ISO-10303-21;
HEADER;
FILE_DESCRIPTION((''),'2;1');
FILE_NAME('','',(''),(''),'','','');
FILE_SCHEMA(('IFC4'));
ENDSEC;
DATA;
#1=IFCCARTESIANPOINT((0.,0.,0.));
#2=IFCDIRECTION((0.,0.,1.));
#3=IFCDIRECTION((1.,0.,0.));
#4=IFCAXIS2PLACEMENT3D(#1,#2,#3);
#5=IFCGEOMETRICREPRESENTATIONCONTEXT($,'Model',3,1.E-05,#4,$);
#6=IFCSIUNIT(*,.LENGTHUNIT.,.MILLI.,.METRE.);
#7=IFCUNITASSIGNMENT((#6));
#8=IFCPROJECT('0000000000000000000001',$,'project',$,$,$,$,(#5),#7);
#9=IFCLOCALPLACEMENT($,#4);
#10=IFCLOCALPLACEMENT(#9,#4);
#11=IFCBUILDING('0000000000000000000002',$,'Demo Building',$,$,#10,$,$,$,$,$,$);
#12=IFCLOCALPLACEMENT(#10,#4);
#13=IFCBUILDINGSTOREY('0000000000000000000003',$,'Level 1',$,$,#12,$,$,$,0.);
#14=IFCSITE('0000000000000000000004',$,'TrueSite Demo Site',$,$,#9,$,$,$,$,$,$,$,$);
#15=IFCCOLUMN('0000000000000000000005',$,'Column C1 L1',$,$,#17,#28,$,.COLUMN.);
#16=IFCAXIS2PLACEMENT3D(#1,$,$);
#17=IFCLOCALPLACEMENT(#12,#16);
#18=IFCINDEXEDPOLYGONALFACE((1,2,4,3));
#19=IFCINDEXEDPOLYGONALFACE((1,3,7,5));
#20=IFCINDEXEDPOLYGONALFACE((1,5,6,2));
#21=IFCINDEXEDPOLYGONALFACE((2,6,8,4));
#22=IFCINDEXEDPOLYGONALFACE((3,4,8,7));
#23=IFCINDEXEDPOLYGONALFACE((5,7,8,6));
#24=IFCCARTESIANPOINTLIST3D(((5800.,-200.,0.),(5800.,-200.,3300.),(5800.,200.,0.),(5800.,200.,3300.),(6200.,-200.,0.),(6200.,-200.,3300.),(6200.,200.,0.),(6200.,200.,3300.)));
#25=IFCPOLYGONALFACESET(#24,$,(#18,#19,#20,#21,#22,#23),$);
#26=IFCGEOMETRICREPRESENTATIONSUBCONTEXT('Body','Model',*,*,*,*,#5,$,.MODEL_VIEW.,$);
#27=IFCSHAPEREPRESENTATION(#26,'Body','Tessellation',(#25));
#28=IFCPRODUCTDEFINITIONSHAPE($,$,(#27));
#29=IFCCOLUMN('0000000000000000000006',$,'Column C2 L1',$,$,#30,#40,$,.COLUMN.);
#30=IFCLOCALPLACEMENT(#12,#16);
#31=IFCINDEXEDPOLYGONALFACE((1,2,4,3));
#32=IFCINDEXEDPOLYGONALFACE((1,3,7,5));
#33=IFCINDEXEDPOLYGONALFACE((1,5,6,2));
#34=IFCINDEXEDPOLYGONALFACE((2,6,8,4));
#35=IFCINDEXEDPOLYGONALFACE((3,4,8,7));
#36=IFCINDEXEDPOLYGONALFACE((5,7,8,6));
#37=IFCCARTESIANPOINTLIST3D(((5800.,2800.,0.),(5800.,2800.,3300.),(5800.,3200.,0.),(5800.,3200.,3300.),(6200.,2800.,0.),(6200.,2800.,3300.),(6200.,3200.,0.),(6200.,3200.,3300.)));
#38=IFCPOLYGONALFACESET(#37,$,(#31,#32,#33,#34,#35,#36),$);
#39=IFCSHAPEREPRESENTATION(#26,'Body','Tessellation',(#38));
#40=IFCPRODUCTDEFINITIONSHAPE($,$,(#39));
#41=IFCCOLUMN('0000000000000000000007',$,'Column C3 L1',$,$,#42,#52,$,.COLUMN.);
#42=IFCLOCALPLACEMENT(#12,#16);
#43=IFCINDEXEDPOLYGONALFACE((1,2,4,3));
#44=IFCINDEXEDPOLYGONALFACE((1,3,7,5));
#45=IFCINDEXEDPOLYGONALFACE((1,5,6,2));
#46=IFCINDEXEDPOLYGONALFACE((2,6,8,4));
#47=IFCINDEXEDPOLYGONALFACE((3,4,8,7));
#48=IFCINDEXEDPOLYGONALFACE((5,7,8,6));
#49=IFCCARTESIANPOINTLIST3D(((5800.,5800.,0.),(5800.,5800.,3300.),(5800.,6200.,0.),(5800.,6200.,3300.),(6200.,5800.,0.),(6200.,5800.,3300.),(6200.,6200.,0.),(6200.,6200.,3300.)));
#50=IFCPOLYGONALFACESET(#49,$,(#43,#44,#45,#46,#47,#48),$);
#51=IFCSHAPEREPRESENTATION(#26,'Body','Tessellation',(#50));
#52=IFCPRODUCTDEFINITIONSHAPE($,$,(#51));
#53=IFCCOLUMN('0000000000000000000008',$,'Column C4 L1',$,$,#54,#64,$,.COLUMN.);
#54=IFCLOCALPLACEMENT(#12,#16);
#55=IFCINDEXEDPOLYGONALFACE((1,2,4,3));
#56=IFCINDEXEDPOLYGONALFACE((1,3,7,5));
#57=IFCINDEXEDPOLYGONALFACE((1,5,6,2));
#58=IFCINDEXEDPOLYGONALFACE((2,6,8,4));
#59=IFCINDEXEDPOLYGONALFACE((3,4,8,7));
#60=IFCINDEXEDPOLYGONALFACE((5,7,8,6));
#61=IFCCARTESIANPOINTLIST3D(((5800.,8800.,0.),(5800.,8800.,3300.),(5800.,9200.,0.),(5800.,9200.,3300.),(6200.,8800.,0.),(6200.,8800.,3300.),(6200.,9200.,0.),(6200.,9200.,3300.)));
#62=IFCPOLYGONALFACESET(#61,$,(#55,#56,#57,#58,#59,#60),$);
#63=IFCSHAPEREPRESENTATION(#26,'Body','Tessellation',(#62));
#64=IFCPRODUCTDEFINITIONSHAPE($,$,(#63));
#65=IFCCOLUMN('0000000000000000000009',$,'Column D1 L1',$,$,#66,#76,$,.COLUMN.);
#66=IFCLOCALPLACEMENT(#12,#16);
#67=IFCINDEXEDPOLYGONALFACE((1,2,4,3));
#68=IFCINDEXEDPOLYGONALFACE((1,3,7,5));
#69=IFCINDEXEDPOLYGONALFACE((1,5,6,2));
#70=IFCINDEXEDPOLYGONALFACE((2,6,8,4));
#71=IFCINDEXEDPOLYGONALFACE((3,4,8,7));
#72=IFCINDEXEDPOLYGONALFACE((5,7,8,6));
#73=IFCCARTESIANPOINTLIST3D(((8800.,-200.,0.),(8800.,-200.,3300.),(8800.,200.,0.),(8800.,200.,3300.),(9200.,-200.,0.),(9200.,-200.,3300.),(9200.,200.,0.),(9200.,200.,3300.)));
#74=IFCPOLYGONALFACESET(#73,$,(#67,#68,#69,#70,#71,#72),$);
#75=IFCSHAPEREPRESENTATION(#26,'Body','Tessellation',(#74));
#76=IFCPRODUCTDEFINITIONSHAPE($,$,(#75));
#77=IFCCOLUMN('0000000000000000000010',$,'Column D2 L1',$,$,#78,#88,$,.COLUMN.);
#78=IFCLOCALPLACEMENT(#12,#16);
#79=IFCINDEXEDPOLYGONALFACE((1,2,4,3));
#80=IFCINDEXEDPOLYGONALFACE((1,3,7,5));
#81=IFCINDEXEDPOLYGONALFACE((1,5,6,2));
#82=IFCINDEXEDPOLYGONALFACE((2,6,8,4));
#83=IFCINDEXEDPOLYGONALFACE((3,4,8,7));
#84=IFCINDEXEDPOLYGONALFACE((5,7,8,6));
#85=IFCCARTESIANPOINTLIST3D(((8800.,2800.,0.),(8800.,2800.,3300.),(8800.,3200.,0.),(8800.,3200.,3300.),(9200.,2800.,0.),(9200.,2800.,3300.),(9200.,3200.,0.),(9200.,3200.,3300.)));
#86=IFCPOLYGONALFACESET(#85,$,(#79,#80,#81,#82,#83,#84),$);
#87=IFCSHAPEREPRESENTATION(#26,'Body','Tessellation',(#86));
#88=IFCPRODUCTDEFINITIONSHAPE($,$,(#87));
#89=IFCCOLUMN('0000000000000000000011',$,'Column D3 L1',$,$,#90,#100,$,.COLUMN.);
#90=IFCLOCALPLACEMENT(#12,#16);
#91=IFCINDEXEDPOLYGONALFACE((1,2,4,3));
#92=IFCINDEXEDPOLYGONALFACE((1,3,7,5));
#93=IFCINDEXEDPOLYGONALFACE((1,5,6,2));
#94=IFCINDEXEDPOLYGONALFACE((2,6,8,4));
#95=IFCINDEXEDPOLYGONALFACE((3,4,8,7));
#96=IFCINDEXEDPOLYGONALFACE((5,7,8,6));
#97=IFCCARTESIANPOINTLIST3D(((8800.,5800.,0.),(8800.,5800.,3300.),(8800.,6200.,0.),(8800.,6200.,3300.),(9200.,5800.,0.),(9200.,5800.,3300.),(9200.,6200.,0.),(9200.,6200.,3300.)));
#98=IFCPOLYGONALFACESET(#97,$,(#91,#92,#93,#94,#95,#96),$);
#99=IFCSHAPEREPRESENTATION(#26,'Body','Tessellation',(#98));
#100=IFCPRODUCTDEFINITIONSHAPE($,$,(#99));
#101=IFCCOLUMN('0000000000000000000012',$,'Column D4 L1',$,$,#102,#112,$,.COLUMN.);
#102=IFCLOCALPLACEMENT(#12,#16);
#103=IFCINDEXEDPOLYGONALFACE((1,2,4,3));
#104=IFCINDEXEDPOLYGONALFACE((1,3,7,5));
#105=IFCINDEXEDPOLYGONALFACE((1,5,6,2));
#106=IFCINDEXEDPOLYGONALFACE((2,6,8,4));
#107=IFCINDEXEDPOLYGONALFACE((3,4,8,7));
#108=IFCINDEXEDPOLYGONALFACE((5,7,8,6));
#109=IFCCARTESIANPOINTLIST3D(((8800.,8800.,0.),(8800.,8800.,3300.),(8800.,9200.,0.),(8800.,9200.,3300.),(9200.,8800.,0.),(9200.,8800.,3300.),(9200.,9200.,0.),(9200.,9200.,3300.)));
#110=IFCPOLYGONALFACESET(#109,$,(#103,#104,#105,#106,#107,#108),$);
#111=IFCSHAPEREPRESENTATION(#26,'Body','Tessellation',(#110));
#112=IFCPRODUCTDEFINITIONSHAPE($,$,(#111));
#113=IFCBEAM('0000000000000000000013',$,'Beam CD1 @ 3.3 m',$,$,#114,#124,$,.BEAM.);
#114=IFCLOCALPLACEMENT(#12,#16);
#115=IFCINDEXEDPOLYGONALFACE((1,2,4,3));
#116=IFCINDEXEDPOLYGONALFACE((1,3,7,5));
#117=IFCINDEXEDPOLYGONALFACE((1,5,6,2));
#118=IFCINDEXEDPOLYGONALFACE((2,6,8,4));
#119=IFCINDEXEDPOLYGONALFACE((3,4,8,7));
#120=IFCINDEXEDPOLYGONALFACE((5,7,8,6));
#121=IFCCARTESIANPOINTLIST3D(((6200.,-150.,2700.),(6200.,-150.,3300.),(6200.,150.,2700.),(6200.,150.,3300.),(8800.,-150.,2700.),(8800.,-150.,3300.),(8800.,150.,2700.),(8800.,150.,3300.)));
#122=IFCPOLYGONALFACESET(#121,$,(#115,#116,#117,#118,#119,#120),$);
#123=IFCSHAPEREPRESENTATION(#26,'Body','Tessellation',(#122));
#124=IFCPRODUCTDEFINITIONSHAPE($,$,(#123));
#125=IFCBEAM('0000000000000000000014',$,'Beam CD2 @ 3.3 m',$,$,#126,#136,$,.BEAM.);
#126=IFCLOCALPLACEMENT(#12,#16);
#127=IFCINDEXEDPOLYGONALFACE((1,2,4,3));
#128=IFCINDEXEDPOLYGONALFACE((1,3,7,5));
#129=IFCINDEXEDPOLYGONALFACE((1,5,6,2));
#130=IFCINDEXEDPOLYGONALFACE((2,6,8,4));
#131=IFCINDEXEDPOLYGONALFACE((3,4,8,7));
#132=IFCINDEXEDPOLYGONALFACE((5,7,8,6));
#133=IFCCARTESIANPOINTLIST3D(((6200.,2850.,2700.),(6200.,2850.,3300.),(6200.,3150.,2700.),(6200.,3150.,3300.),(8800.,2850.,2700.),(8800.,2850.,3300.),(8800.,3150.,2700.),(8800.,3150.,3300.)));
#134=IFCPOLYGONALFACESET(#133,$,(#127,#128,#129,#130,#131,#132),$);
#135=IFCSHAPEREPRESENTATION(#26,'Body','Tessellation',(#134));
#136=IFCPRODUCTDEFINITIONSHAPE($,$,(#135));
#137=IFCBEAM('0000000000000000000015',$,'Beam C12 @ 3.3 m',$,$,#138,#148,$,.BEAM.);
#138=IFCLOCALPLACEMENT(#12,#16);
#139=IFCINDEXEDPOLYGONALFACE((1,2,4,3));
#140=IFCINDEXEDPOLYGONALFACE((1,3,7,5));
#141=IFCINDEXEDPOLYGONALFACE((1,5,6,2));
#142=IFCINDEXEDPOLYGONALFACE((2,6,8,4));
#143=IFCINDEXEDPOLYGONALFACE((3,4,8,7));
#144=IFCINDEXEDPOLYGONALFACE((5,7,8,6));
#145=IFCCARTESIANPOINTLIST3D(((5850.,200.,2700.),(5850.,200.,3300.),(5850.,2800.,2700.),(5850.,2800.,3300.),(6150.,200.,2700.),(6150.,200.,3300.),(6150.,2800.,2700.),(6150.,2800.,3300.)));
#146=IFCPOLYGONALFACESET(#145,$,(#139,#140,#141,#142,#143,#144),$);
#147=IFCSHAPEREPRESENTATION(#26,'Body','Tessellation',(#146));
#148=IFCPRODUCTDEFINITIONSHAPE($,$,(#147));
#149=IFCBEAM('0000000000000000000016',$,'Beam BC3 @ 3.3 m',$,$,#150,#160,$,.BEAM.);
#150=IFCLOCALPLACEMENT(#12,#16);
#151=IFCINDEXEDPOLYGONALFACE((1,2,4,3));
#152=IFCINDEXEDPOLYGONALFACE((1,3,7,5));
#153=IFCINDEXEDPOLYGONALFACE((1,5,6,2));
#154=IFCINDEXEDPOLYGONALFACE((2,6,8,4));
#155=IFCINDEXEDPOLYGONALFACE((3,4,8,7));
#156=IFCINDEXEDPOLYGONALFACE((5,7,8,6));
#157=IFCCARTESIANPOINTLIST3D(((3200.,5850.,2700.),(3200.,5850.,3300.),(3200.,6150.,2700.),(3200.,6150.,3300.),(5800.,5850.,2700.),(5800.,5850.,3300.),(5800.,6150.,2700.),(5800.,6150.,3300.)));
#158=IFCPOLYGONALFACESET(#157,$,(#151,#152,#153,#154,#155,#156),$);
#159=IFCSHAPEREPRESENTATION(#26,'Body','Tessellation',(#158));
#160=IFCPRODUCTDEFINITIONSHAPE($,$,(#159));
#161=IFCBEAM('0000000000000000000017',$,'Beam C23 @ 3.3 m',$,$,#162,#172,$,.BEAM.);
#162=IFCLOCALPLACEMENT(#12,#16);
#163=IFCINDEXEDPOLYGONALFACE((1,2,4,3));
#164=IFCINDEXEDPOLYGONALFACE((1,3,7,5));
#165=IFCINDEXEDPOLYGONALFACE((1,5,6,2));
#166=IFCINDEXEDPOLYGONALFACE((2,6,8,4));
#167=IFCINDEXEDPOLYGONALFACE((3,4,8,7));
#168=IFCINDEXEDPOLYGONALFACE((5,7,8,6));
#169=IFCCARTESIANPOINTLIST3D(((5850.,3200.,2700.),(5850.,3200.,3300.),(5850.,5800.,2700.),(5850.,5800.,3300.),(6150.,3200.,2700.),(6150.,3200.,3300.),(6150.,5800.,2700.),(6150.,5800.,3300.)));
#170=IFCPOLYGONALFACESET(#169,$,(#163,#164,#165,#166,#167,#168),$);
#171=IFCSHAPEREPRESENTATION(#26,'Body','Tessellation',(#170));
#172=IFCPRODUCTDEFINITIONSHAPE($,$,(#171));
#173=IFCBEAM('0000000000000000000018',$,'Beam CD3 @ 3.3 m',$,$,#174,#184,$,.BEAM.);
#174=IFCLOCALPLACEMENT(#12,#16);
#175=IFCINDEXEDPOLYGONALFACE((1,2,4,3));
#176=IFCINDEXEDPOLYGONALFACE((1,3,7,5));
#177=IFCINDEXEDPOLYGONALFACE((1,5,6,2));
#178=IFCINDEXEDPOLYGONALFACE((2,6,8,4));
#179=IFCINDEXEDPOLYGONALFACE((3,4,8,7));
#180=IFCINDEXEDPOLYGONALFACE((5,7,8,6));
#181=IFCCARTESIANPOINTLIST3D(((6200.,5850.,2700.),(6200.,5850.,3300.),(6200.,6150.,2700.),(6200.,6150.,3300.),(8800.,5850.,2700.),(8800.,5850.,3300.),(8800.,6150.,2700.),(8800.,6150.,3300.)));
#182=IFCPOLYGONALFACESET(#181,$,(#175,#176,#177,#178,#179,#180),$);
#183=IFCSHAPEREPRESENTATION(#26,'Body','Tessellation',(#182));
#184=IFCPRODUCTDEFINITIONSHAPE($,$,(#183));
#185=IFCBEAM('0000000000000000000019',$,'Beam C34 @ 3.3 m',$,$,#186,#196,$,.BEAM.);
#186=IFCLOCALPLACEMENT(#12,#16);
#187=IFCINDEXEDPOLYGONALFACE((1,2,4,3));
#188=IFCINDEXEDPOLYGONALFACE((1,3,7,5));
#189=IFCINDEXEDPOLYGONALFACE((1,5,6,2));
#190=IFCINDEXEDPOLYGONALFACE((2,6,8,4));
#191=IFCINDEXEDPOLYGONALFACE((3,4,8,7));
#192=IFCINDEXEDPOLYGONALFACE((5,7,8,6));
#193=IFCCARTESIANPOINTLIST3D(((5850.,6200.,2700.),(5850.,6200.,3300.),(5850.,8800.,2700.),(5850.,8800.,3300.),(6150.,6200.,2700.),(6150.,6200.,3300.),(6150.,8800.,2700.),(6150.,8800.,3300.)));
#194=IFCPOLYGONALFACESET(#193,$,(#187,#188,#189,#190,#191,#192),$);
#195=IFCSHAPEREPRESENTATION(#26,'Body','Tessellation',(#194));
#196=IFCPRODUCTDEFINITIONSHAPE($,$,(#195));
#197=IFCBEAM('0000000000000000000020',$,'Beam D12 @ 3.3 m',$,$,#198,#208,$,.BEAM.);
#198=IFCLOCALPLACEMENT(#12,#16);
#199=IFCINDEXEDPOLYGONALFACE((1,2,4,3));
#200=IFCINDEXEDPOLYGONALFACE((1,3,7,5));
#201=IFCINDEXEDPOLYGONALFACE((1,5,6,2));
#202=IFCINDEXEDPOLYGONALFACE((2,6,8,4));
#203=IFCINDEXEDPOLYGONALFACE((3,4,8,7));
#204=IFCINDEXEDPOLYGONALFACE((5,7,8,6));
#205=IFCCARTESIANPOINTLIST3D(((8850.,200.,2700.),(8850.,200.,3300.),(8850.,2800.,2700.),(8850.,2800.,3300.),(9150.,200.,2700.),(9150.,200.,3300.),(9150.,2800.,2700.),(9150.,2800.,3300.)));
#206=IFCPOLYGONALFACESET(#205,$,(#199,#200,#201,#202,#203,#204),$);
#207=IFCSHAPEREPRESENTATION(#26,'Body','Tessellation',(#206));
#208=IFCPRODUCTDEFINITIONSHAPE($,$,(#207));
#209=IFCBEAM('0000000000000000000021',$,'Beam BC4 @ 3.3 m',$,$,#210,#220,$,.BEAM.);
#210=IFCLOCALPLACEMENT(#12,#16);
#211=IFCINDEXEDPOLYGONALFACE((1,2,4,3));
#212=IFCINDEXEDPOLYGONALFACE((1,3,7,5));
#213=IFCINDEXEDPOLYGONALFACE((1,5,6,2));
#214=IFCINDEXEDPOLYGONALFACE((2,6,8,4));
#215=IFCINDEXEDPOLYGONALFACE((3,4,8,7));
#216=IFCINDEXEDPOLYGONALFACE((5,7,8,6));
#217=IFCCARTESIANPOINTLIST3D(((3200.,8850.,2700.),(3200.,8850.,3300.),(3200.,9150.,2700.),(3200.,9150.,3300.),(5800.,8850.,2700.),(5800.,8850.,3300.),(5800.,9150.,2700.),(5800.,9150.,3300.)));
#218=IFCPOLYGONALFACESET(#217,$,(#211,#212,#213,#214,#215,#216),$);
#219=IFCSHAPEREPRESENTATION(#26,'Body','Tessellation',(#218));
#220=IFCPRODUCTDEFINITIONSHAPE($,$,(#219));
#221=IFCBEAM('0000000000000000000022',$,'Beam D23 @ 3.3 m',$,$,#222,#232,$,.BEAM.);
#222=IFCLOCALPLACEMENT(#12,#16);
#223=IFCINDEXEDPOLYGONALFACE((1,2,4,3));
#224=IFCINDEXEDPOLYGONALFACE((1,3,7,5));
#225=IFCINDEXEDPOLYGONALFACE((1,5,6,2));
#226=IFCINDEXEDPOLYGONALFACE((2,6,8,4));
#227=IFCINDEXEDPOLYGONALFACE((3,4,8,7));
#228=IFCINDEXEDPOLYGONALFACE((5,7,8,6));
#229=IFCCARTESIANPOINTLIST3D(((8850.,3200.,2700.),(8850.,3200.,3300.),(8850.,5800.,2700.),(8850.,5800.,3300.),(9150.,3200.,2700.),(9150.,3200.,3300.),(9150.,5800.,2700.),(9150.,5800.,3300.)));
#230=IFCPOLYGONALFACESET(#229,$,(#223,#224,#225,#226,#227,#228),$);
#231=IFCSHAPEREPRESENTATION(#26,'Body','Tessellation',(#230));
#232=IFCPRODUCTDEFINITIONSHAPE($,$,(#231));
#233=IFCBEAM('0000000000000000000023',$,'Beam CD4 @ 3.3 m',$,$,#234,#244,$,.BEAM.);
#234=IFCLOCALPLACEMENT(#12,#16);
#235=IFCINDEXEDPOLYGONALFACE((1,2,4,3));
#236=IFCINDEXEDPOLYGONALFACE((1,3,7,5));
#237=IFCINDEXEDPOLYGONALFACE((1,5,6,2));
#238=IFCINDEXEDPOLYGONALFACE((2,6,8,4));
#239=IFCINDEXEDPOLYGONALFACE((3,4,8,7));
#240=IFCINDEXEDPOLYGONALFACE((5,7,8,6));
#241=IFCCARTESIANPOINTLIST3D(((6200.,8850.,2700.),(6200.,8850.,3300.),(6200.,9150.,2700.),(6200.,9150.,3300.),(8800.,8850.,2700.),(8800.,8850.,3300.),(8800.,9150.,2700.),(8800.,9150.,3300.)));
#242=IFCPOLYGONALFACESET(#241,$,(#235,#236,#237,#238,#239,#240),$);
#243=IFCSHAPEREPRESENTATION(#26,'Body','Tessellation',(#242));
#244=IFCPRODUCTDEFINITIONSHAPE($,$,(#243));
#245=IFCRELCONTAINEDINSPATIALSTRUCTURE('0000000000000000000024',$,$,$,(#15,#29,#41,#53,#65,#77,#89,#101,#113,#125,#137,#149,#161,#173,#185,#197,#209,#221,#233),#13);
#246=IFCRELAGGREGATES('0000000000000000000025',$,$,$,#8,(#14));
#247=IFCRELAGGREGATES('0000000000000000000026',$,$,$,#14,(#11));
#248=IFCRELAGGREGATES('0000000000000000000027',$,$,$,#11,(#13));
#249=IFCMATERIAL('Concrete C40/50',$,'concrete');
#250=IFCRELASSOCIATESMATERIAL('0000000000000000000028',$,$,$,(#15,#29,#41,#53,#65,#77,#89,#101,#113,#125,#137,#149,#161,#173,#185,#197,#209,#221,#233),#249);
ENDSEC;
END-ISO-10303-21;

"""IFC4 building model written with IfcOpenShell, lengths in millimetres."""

from ifc_helpers import new_model, si_unit, frame, origin_with_axes, place, context, subcontext, project, spatial, rectangle, extrude, material, element, save


model = new_model("IFC4")

# Units and contexts
model_context = context("Model", 3, precision=1e-05, world=origin_with_axes())
body_context = subcontext(model_context, "Body", "Model", "MODEL_VIEW")
ifc_project = project(units=[si_unit("LENGTHUNIT", "METRE", prefix="MILLI")], contexts=[model_context])

# Site, building, storey
site_placement = place(None, origin_with_axes())
site = spatial("IfcSite", under=ifc_project, at=site_placement, Name="TrueSite Demo Site")
building_placement = place(site_placement, origin_with_axes())
building = spatial("IfcBuilding", under=site, at=building_placement, Name="Demo Building")
storey_placement = place(building_placement, origin_with_axes())
storey = spatial("IfcBuildingStorey", under=building, at=storey_placement, Name="Level 1", Elevation=0.0)

# Columns
ifc_material_1 = material(Name="Concrete C40/50", Category="concrete")
for number, where, z_axis, x_axis, name in (
    (1, (6000.0, 0.0, 0.0), (0.0, 0.0, 1.0), (1.0, 0.0, 0.0), "Column C1 L1"),
    (2, (6000.0, 3000.0, 0.0), (0.0, 0.0, 1.0), (1.0, 0.0, 0.0), "Column C2 L1"),
    (3, (6000.0, 6000.0, 0.0), (0.0, 0.0, 1.0), (1.0, 0.0, 0.0), "Column C3 L1"),
    (4, (6000.0, 9000.0, 0.0), (0.0, 0.0, 1.0), (1.0, 0.0, 0.0), "Column C4 L1"),
    (5, (9000.0, 0.0, 0.0), (0.0, 0.0, 1.0), (1.0, 0.0, 0.0), "Column D1 L1"),
    (6, (9000.0, 3000.0, 0.0), (0.0, 0.0, 1.0), (1.0, 0.0, 0.0), "Column D2 L1"),
    (7, (9000.0, 6000.0, 0.0), (0.0, 0.0, 1.0), (1.0, 0.0, 0.0), "Column D3 L1"),
    (8, (9000.0, 9000.0, 0.0), (0.0, 0.0, 1.0), (1.0, 0.0, 0.0), "Column D4 L1"),
):
    element("IfcColumn", number, at=place(storey_placement, frame(where, z_axis=z_axis, x_axis=x_axis)), inside=storey, material=ifc_material_1, Name=name, PredefinedType="COLUMN", context=body_context, shape_type="SweptSolid", body=[
        extrude(rectangle(XDim=400.0, YDim=400.0), origin_with_axes(), (0.0, 0.0, 1.0), 3300.0),
    ])

# Beams
for number, where, z_axis, x_axis, name in (
    (9, (6200.0, 0.0, 3000.0), (1.0, 0.0, 0.0), (0.0, 1.0, 0.0), "Beam CD1 @ 3.3 m"),
    (10, (6200.0, 3000.0, 3000.0), (1.0, 0.0, 0.0), (0.0, 1.0, 0.0), "Beam CD2 @ 3.3 m"),
):
    element("IfcBeam", number, at=place(storey_placement, frame(where, z_axis=z_axis, x_axis=x_axis)), inside=storey, material=ifc_material_1, Name=name, PredefinedType="BEAM", context=body_context, shape_type="SweptSolid", body=[
        extrude(rectangle(XDim=300.0, YDim=600.0), origin_with_axes(), (0.0, 0.0, 1.0), 2600.0),
    ])
for number, where, z_axis, x_axis, name in (
    (11, (6000.0, 200.0, 3000.0), (0.0, 1.0, 0.0), (1.0, 0.0, 0.0), "Beam C12 @ 3.3 m"),
    (12, (3200.0, 6000.0, 3000.0), (1.0, 0.0, 0.0), (0.0, 1.0, 0.0), "Beam BC3 @ 3.3 m"),
    (13, (6000.0, 3200.0, 3000.0), (0.0, 1.0, 0.0), (1.0, 0.0, 0.0), "Beam C23 @ 3.3 m"),
):
    element("IfcBeam", number, at=place(storey_placement, frame(where, z_axis=z_axis, x_axis=x_axis)), inside=storey, material=ifc_material_1, Name=name, PredefinedType="BEAM", context=body_context, shape_type="SweptSolid", body=[
        extrude(rectangle(XDim=300.0, YDim=600.0), origin_with_axes(), (0.0, 0.0, 1.0), 2600.0),
    ])
for number, where, z_axis, x_axis, name in (
    (14, (6200.0, 6000.0, 3000.0), (1.0, 0.0, 0.0), (0.0, 1.0, 0.0), "Beam CD3 @ 3.3 m"),
    (15, (6000.0, 6200.0, 3000.0), (0.0, 1.0, 0.0), (1.0, 0.0, 0.0), "Beam C34 @ 3.3 m"),
):
    element("IfcBeam", number, at=place(storey_placement, frame(where, z_axis=z_axis, x_axis=x_axis)), inside=storey, material=ifc_material_1, Name=name, PredefinedType="BEAM", context=body_context, shape_type="SweptSolid", body=[
        extrude(rectangle(XDim=300.0, YDim=600.0), origin_with_axes(), (0.0, 0.0, 1.0), 2600.0),
    ])
for number, where, z_axis, x_axis, name in (
    (16, (9000.0, 200.0, 3000.0), (0.0, 1.0, 0.0), (1.0, 0.0, 0.0), "Beam D12 @ 3.3 m"),
    (17, (3200.0, 9000.0, 3000.0), (1.0, 0.0, 0.0), (0.0, 1.0, 0.0), "Beam BC4 @ 3.3 m"),
    (18, (9000.0, 3200.0, 3000.0), (0.0, 1.0, 0.0), (1.0, 0.0, 0.0), "Beam D23 @ 3.3 m"),
):
    element("IfcBeam", number, at=place(storey_placement, frame(where, z_axis=z_axis, x_axis=x_axis)), inside=storey, material=ifc_material_1, Name=name, PredefinedType="BEAM", context=body_context, shape_type="SweptSolid", body=[
        extrude(rectangle(XDim=300.0, YDim=600.0), origin_with_axes(), (0.0, 0.0, 1.0), 2600.0),
    ])
for number, where, z_axis, x_axis, name in (
    (19, (6200.0, 9000.0, 3000.0), (1.0, 0.0, 0.0), (0.0, 1.0, 0.0), "Beam CD4 @ 3.3 m"),
):
    element("IfcBeam", number, at=place(storey_placement, frame(where, z_axis=z_axis, x_axis=x_axis)), inside=storey, material=ifc_material_1, Name=name, PredefinedType="BEAM", context=body_context, shape_type="SweptSolid", body=[
        extrude(rectangle(XDim=300.0, YDim=600.0), origin_with_axes(), (0.0, 0.0, 1.0), 2600.0),
    ])

save(model, "model.ifc")
